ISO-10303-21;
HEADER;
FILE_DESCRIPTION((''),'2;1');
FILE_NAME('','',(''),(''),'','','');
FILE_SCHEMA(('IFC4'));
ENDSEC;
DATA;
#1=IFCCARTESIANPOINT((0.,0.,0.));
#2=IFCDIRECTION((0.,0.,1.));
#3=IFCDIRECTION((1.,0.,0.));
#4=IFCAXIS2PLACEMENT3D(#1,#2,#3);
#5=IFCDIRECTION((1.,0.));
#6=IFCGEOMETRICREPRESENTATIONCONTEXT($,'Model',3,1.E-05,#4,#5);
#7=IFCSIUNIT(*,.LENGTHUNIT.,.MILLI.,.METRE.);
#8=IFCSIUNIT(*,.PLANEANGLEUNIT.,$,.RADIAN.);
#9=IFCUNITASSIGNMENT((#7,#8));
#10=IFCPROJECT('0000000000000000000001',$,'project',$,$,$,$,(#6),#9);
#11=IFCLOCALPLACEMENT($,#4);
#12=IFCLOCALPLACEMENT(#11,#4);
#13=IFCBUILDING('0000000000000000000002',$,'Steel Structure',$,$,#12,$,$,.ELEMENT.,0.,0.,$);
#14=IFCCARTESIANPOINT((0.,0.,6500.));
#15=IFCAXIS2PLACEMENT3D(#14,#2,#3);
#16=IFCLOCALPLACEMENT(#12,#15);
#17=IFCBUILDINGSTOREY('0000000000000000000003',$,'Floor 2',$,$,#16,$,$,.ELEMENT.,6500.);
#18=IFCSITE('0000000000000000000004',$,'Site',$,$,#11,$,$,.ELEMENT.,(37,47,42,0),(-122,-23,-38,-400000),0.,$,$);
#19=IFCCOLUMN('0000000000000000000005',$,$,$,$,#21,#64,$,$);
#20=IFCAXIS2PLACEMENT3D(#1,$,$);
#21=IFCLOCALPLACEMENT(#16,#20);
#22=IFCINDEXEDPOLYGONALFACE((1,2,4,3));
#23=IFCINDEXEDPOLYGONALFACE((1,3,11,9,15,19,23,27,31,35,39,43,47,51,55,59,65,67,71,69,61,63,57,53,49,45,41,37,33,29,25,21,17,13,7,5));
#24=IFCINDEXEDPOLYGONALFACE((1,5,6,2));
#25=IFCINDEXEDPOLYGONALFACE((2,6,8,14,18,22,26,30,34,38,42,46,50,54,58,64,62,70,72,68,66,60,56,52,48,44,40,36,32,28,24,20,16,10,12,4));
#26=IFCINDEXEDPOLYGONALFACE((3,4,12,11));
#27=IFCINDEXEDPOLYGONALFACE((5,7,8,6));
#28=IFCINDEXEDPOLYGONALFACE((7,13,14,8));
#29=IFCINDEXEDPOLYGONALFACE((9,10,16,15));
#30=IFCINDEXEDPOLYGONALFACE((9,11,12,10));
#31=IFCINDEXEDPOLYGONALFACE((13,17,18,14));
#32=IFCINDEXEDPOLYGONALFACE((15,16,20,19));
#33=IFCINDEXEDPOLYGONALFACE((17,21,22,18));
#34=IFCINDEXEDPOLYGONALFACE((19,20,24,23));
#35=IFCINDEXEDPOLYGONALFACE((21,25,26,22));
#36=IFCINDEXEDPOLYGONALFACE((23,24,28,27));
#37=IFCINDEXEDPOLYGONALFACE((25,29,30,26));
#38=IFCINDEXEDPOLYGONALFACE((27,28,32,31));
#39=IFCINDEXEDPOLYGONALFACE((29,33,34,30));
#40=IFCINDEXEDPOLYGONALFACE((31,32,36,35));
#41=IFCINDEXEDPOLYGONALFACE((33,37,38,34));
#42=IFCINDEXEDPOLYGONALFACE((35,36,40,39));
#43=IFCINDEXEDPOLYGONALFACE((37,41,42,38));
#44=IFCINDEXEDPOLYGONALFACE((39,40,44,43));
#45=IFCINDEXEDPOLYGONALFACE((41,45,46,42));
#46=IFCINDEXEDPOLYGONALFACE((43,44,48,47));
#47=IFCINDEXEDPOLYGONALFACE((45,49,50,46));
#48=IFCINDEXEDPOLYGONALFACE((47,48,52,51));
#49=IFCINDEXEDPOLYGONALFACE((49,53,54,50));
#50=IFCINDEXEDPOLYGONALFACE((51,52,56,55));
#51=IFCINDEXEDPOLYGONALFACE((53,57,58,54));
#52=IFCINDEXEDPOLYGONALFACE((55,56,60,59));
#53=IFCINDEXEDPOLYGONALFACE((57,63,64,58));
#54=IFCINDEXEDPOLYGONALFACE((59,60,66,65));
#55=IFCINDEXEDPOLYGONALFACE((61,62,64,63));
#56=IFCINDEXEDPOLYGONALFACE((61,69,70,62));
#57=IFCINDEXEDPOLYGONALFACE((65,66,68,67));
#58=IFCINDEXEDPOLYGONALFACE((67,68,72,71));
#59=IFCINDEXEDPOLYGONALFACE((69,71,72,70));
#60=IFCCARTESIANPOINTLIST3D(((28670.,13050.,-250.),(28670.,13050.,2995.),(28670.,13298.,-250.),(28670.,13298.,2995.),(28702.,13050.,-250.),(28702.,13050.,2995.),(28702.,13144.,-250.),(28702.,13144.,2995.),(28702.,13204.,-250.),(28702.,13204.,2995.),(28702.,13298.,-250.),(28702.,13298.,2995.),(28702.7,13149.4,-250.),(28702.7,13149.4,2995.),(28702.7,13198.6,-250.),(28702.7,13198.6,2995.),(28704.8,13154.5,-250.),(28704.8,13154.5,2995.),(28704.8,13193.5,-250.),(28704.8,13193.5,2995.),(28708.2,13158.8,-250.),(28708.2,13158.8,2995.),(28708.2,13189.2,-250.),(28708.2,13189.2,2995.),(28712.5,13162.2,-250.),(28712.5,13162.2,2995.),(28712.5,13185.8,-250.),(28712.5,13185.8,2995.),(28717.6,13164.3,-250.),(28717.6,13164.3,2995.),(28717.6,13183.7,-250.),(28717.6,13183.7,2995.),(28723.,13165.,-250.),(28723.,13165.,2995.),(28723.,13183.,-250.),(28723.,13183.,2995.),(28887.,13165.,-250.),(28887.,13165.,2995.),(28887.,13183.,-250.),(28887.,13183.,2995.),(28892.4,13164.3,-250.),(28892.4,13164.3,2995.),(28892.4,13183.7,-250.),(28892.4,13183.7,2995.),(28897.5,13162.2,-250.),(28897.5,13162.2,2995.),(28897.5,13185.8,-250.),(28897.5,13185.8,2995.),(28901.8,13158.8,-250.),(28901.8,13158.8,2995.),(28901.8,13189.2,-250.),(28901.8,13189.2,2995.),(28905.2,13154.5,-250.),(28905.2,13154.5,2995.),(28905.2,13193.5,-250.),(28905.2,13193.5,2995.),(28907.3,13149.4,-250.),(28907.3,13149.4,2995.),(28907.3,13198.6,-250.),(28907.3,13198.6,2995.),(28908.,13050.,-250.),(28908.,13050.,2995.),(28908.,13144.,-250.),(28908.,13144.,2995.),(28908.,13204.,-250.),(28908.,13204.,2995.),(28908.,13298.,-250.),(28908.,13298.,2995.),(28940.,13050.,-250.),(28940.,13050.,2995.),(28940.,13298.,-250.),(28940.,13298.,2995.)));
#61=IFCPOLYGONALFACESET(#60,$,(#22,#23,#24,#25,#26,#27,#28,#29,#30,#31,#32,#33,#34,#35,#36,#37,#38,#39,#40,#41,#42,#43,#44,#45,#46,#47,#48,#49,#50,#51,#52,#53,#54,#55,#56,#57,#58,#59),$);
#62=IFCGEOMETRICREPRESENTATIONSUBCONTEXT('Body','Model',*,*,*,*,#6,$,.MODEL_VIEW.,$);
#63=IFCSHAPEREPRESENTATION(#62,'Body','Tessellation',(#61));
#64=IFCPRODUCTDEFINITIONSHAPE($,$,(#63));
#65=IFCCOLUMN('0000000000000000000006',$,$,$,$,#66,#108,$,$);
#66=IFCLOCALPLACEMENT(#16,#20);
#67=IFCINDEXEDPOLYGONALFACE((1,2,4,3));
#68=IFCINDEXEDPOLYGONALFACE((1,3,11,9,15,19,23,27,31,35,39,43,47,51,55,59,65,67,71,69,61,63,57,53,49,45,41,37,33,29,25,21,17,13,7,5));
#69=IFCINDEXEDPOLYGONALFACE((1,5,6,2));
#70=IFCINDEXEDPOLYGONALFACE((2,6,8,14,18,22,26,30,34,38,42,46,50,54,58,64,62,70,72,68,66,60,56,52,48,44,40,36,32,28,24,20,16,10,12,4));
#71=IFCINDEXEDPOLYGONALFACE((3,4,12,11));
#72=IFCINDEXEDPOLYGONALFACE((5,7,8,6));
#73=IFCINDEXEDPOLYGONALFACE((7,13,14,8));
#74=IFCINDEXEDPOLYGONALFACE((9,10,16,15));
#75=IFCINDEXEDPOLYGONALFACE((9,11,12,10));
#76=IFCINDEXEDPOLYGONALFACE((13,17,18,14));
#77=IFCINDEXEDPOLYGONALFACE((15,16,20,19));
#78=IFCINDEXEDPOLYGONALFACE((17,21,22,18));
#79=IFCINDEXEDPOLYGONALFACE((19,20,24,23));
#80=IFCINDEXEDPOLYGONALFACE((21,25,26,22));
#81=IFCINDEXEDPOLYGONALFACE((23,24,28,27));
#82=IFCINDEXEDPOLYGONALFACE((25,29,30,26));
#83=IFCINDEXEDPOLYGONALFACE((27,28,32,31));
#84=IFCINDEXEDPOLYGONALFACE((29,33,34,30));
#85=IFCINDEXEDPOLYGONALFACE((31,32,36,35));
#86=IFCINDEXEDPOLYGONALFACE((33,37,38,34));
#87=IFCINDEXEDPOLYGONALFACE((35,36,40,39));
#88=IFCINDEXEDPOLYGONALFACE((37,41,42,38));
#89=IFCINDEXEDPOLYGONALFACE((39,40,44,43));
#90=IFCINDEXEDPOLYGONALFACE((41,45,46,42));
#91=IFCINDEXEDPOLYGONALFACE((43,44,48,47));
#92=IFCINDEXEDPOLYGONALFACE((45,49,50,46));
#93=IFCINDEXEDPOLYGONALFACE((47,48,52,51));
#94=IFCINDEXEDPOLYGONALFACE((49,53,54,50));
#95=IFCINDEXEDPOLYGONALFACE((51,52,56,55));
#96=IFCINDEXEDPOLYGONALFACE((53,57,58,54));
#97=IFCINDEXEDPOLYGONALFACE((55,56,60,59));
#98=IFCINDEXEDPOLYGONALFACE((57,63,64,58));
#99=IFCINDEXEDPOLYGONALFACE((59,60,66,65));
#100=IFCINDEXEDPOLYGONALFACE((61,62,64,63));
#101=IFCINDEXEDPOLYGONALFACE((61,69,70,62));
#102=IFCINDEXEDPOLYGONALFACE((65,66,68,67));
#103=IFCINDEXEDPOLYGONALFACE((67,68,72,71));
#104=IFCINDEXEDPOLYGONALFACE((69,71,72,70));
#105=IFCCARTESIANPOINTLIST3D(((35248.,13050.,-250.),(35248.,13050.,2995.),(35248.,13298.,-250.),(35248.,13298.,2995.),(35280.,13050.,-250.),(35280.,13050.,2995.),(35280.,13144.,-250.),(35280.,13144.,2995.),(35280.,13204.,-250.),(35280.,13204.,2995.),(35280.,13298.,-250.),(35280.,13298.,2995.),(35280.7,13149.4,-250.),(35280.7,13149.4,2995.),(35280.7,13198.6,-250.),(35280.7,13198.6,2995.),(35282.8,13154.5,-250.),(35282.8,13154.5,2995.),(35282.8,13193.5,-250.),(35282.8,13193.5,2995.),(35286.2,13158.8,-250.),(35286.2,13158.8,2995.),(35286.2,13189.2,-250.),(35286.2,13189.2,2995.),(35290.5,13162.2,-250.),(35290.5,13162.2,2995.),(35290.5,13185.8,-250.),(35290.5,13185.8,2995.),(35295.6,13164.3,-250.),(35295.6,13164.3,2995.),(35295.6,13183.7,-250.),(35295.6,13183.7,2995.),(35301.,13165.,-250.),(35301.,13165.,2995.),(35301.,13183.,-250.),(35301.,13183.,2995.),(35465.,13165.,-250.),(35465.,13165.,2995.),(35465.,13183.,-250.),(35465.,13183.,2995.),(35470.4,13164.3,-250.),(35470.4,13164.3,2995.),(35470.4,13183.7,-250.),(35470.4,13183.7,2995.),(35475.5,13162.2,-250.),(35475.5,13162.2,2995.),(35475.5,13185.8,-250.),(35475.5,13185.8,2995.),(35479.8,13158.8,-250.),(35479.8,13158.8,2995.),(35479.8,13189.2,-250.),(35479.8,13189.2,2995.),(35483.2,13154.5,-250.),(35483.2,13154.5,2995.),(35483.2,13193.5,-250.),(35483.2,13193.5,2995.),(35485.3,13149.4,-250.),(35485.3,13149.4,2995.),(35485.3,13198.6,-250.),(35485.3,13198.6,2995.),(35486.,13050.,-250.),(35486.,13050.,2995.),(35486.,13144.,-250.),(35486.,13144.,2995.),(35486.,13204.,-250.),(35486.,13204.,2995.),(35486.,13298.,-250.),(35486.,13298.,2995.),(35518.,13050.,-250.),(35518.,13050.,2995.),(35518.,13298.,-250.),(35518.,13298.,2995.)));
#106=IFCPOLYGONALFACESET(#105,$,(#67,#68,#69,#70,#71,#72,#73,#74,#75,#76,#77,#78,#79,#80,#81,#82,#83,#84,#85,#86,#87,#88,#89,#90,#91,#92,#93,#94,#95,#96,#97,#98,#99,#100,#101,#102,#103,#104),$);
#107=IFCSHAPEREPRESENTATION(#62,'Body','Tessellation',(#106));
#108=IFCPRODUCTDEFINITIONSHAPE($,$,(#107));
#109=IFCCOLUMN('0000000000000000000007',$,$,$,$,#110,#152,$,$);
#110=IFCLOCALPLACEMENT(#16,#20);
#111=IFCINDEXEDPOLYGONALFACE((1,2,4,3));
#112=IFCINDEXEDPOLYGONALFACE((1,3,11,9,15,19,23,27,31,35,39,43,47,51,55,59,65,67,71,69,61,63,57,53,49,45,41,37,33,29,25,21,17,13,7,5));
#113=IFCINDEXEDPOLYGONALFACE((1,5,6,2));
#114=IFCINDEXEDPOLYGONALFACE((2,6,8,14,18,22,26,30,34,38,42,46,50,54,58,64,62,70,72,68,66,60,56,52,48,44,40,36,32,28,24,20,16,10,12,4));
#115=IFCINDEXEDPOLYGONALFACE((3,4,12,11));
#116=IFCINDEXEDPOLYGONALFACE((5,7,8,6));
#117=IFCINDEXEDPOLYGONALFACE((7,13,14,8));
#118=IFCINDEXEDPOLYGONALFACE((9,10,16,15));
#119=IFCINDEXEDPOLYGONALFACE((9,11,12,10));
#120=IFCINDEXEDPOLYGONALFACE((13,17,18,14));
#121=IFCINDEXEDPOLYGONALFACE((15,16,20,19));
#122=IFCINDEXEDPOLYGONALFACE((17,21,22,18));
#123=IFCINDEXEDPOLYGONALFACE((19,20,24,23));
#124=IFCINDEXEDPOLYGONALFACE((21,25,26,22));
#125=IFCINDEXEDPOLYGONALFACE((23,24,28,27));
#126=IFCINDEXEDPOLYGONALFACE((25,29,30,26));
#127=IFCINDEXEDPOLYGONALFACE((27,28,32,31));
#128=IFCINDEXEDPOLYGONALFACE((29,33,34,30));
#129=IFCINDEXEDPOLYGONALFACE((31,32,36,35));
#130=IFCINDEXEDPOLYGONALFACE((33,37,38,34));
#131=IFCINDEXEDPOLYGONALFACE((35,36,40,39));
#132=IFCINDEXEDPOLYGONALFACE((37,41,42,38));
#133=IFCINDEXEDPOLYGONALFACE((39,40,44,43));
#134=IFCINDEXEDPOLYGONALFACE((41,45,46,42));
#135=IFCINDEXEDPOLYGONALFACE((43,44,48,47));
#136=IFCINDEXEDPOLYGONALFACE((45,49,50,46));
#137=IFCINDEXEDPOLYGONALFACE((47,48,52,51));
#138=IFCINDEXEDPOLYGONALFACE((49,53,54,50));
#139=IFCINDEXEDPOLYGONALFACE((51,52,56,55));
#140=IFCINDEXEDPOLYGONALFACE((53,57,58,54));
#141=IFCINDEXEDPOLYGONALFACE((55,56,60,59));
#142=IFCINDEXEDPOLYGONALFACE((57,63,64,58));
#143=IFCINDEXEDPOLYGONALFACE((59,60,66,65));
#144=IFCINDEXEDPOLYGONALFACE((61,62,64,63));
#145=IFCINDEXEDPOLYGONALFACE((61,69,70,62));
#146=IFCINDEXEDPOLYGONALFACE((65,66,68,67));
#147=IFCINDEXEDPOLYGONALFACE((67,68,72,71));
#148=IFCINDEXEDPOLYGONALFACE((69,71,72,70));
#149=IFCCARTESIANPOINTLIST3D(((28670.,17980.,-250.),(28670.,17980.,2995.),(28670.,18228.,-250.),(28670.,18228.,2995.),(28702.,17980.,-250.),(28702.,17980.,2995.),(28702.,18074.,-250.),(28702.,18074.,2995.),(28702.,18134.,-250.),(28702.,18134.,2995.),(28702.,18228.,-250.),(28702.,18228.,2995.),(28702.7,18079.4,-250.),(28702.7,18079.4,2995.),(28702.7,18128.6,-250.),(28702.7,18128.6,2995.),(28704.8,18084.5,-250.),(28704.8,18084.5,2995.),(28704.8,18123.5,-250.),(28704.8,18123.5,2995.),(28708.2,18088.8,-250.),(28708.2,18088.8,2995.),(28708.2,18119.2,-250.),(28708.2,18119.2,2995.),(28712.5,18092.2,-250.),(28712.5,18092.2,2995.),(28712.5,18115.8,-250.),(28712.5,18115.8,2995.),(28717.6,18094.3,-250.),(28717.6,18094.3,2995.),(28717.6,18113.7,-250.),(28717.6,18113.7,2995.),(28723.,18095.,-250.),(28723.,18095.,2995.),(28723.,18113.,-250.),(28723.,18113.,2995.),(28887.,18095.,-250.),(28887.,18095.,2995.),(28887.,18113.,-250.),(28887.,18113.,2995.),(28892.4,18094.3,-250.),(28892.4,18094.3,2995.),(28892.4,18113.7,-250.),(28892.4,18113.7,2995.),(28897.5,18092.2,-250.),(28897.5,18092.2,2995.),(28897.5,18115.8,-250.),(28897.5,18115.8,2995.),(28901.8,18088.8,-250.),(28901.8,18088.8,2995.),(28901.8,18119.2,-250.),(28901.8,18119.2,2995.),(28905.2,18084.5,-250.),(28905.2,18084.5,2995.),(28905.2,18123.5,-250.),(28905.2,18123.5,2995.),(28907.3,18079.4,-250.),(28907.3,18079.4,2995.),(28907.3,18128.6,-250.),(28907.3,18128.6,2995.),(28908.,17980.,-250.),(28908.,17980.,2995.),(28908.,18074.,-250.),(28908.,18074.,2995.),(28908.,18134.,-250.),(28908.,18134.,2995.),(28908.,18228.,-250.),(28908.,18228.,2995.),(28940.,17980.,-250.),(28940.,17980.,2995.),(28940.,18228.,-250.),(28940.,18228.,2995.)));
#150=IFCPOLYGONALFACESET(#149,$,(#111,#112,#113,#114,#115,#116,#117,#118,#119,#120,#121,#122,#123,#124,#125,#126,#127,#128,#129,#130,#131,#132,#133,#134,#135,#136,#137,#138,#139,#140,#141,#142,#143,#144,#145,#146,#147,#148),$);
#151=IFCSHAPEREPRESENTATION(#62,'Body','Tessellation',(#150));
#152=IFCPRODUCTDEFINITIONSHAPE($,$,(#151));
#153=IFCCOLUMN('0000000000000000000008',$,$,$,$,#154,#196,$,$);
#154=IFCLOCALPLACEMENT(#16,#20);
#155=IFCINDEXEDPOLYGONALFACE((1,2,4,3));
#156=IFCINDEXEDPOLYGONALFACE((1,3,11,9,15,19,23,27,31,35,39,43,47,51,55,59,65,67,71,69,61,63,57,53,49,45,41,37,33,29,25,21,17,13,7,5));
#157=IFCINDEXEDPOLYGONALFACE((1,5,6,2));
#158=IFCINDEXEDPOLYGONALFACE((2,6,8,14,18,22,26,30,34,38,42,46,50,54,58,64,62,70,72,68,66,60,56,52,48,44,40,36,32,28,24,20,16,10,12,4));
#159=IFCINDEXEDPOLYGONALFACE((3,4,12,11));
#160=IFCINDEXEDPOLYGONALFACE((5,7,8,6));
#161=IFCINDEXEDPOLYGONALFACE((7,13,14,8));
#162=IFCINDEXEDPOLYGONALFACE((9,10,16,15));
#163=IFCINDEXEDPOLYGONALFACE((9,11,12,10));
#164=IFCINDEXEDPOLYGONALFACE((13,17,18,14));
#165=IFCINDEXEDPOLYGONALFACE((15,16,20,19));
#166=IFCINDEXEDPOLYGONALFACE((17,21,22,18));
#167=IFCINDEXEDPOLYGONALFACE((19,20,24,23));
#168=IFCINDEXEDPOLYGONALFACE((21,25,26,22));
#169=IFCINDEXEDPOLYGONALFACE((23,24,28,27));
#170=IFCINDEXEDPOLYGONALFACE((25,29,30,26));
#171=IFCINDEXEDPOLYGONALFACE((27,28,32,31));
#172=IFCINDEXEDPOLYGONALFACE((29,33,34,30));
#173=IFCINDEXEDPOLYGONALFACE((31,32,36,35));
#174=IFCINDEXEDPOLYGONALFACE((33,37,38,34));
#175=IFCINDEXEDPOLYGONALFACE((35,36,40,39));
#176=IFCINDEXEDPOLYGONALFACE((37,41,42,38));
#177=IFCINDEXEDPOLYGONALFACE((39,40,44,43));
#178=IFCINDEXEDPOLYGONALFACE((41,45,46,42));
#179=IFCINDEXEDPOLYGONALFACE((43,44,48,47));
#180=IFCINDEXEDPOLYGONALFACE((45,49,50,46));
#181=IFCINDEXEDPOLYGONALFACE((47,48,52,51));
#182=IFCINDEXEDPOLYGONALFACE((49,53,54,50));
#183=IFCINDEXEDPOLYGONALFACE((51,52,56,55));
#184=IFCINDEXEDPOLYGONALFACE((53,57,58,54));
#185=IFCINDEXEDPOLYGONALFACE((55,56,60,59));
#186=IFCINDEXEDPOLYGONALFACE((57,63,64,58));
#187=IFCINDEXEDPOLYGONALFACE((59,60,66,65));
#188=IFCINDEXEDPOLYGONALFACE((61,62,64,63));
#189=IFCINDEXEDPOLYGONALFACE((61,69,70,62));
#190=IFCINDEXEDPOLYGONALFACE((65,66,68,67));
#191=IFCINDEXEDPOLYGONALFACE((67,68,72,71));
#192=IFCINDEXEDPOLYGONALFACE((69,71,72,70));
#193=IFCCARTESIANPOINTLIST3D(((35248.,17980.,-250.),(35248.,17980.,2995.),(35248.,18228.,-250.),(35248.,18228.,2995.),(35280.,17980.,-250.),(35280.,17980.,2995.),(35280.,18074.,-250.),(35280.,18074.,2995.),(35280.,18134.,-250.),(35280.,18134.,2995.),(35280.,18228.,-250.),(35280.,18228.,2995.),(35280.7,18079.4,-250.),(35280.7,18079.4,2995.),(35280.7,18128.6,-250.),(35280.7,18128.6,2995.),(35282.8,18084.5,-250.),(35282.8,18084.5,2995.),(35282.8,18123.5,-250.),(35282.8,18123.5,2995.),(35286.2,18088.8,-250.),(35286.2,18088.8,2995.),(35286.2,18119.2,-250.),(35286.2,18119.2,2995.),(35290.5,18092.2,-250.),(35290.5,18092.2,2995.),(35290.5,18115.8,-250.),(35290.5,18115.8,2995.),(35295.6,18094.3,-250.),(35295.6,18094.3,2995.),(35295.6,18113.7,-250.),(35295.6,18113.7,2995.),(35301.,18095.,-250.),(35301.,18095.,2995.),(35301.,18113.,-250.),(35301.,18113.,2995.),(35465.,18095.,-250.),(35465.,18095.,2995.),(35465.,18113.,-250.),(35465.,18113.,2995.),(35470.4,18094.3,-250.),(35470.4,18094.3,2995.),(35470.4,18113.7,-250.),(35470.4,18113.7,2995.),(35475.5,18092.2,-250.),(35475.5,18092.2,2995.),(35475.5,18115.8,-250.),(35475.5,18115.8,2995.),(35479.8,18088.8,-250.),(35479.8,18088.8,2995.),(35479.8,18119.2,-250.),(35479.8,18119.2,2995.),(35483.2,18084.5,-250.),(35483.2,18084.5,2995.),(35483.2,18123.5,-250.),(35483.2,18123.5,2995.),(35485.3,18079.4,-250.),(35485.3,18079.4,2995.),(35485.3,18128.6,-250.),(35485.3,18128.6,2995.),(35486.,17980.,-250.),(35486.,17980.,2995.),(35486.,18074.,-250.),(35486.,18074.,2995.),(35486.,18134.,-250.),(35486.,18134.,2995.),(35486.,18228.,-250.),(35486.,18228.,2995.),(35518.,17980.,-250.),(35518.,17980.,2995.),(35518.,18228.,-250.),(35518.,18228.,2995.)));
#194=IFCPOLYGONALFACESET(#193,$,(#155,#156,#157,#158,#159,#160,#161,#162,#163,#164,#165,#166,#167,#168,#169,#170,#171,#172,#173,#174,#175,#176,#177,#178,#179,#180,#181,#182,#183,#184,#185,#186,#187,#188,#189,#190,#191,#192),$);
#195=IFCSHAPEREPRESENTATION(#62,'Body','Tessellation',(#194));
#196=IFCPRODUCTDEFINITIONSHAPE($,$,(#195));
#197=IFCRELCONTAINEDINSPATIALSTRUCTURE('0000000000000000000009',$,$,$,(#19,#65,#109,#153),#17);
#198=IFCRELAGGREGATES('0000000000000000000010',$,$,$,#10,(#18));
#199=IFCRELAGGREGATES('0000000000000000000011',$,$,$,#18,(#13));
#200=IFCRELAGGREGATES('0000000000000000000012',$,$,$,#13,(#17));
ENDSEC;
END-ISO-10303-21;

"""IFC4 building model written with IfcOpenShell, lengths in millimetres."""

from ifc_helpers import new_model, si_unit, direction, frame, origin_with_axes, origin_2d_with_axis, place, context, subcontext, project, spatial, i_section, extrude, element, save


model = new_model("IFC4")

# Units and contexts
model_context = context("Model", 3, precision=1e-05, world=origin_with_axes(), true_north=direction((1.0, 0.0)))
body_context = subcontext(model_context, "Body", "Model", "MODEL_VIEW")
ifc_project = project(units=[si_unit("LENGTHUNIT", "METRE", prefix="MILLI"), si_unit("PLANEANGLEUNIT", "RADIAN")], contexts=[model_context])

# Site, building, storey
site_placement = place(None, origin_with_axes())
site = spatial("IfcSite", under=ifc_project, at=site_placement, Name="Site", CompositionType="ELEMENT", RefLatitude=(37, 47, 42, 0), RefLongitude=(-122, -23, -38, -400000), RefElevation=0.0)
building_placement = place(site_placement, origin_with_axes())
building = spatial("IfcBuilding", under=site, at=building_placement, Name="Steel Structure", CompositionType="ELEMENT", ElevationOfRefHeight=0.0, ElevationOfTerrain=0.0)
storey_placement = place(building_placement, frame((0.0, 0.0, 6500.0), z_axis=(0.0, 0.0, 1.0), x_axis=(1.0, 0.0, 0.0)))
storey = spatial("IfcBuildingStorey", under=building, at=storey_placement, Name="Floor 2", CompositionType="ELEMENT", Elevation=6500.0)

# Columns
for number, where, z_axis, x_axis in (
    (1, (28805.0, 13174.0, -250.0), (0.0, 0.0, 1.0), (0.0, 1.0, 0.0)),
    (2, (35383.0, 13174.0, -250.0), (0.0, 0.0, 1.0), (0.0, 1.0, 0.0)),
    (3, (28805.0, 18104.0, -250.0), (0.0, 0.0, 1.0), (0.0, 1.0, 0.0)),
    (4, (35383.0, 18104.0, -250.0), (0.0, 0.0, 1.0), (0.0, 1.0, 0.0)),
):
    element("IfcColumn", number, at=place(storey_placement, frame(where, z_axis=z_axis, x_axis=x_axis)), inside=storey, context=body_context, shape_type="SweptSolid", body=[
        extrude(i_section(OverallWidth=248.0, OverallDepth=270.0, WebThickness=18.0, FlangeThickness=32.0, FilletRadius=21.0, at=origin_2d_with_axis()), origin_with_axes(), (0.0, 0.0, 1.0), 3245.0),
    ])

save(model, "model.ifc")
